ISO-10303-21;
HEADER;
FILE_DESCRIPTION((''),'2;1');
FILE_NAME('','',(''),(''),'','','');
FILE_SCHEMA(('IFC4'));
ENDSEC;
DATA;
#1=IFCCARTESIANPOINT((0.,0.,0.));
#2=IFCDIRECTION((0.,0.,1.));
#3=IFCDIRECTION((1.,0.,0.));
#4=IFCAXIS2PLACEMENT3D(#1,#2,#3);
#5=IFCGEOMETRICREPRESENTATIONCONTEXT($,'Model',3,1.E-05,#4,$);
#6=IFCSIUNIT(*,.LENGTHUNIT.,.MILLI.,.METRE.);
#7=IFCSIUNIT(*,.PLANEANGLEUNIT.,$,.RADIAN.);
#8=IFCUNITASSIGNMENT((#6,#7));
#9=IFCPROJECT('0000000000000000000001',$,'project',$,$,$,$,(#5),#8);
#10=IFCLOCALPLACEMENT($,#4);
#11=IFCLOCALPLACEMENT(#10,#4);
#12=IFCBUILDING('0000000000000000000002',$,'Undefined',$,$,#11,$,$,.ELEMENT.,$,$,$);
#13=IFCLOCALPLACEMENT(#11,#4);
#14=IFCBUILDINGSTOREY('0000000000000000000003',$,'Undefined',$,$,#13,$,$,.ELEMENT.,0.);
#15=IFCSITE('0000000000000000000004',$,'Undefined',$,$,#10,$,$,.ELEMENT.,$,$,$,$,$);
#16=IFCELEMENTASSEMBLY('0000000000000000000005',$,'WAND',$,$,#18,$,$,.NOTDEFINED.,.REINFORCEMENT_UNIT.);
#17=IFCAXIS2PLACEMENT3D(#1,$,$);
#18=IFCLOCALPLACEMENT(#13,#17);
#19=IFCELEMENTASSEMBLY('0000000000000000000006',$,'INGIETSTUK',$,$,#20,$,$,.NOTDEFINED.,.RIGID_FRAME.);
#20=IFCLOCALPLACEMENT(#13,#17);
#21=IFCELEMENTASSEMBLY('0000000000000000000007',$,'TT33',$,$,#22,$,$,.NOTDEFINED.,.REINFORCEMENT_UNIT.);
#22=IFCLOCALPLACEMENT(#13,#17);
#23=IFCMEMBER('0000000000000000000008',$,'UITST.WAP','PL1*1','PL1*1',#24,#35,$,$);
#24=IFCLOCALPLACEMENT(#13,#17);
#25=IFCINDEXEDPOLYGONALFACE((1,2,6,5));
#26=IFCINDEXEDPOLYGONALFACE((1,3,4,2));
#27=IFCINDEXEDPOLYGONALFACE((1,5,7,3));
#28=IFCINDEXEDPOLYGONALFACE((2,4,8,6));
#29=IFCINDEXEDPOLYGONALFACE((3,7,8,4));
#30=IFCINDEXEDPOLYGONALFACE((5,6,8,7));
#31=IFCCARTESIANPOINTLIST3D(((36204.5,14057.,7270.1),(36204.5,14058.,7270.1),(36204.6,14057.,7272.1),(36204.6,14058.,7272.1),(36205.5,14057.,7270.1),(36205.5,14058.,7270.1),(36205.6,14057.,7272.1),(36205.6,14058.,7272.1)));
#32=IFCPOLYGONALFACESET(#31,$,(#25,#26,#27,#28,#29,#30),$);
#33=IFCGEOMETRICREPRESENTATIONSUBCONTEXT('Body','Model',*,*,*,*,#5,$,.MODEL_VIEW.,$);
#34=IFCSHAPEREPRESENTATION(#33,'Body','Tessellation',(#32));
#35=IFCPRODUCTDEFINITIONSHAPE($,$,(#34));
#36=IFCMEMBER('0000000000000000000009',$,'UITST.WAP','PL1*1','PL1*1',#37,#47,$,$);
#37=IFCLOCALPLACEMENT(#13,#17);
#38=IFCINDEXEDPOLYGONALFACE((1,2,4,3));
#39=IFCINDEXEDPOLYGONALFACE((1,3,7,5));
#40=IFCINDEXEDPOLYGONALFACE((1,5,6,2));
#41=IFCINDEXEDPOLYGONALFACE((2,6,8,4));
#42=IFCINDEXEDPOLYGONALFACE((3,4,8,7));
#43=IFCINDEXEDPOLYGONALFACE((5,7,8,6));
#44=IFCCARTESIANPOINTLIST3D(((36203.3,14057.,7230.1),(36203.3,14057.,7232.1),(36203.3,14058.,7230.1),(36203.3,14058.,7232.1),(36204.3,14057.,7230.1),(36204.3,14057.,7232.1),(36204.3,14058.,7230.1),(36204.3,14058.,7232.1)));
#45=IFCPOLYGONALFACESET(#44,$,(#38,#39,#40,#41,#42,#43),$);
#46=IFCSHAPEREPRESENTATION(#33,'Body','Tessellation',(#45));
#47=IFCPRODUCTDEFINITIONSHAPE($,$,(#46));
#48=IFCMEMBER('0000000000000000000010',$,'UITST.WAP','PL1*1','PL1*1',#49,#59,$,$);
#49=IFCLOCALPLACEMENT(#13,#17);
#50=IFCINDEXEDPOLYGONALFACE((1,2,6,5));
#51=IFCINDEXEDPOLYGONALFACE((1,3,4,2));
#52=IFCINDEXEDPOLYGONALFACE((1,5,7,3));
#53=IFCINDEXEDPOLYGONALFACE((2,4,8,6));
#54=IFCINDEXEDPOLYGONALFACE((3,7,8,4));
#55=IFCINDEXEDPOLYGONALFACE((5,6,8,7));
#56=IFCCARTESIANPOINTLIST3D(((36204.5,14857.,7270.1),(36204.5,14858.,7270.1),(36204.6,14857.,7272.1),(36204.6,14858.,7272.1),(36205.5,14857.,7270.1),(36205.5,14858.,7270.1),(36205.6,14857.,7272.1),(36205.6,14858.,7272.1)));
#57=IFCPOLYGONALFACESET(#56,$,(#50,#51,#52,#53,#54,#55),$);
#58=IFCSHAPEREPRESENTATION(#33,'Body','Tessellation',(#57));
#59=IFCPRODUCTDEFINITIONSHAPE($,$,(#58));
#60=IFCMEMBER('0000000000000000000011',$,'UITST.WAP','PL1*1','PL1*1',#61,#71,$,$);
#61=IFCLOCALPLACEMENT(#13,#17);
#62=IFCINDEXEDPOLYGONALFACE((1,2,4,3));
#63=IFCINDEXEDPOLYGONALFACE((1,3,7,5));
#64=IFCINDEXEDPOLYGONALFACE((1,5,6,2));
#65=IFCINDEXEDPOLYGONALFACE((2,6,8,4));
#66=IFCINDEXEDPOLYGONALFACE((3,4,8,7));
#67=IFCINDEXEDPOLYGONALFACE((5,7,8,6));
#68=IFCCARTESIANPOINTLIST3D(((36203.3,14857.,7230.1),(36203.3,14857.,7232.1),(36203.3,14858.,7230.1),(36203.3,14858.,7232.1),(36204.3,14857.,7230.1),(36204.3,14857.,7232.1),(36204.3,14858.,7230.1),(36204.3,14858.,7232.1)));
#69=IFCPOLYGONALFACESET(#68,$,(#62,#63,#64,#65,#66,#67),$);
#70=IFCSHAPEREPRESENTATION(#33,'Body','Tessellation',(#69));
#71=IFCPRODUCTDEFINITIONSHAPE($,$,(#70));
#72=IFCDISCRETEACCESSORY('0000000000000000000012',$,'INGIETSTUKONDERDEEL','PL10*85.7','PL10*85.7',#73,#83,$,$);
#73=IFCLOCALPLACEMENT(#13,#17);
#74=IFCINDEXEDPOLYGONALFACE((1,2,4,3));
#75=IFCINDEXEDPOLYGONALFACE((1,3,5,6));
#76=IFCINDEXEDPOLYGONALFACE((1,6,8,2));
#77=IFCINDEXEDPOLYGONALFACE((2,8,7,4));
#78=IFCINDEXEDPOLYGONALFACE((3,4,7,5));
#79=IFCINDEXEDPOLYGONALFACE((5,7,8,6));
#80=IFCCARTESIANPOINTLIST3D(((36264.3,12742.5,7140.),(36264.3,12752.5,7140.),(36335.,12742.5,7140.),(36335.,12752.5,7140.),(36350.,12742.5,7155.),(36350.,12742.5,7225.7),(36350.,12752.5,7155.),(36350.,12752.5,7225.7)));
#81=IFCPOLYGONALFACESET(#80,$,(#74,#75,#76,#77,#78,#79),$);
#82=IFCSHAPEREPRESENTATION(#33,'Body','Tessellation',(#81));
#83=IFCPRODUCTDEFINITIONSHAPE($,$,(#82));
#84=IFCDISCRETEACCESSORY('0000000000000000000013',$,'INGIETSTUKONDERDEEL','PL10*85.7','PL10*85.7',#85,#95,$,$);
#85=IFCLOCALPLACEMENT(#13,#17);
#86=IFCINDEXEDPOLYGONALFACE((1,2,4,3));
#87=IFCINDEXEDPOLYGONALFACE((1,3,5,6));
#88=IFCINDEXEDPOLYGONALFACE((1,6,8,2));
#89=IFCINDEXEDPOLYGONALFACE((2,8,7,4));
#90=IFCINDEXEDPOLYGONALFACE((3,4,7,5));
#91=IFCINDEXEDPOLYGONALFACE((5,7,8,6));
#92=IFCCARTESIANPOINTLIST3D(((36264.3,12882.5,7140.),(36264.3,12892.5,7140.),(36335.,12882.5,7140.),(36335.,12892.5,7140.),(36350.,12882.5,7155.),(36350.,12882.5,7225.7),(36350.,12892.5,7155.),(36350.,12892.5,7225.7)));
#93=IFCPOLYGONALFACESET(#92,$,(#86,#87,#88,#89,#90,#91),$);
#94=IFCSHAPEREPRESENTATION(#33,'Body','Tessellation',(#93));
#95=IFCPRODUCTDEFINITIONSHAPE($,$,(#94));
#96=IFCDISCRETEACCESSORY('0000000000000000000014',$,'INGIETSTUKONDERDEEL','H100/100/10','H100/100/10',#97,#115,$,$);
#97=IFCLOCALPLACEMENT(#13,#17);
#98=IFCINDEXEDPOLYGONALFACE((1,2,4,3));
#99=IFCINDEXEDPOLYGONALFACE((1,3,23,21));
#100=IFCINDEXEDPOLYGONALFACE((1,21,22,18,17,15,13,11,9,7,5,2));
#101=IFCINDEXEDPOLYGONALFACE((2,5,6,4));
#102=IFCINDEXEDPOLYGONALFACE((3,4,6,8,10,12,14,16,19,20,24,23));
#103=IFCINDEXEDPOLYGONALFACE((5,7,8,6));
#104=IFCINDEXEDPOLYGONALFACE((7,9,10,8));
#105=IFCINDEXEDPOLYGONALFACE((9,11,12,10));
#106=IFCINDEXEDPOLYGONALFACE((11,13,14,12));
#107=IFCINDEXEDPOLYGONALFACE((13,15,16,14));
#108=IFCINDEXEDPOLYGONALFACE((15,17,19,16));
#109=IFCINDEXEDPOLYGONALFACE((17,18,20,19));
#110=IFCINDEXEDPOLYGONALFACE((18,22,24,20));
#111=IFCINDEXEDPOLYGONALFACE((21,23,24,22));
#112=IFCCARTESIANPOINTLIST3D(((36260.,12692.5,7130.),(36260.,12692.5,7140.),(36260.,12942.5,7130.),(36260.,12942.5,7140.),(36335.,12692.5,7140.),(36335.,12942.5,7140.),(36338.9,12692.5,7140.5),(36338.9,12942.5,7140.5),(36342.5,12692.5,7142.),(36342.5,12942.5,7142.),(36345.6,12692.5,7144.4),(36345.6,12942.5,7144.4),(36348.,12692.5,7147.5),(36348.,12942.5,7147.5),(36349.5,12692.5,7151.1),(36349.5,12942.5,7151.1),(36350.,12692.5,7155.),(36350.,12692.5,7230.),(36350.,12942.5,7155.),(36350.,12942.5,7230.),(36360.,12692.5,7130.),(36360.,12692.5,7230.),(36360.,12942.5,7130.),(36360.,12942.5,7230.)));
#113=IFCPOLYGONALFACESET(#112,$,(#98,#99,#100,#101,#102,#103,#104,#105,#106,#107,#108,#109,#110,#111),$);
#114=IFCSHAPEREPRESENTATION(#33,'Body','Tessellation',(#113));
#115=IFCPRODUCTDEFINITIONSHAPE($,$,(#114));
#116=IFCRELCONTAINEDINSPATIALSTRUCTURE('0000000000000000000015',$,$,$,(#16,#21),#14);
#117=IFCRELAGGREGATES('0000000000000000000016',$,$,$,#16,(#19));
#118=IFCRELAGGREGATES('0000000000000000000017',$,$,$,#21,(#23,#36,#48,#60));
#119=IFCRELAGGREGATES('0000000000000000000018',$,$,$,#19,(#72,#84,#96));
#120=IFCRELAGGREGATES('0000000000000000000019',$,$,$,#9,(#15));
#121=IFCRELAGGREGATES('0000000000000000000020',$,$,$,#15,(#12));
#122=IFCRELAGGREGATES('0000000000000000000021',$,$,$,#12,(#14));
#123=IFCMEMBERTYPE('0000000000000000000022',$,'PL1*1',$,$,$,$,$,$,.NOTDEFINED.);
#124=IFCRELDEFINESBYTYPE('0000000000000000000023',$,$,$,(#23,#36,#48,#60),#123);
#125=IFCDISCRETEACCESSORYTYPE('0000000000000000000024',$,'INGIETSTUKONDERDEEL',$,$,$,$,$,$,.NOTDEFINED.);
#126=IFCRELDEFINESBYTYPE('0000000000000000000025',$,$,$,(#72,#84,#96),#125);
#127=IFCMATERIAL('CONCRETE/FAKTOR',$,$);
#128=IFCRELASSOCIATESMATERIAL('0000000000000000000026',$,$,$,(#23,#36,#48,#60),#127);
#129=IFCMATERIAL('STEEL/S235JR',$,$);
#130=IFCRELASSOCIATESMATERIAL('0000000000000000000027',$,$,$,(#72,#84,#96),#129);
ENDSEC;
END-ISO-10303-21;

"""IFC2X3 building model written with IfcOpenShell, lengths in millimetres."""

from ifc_helpers import new_model, si_unit, frame, frame_2d, origin_with_axes, place, context, subcontext, project, spatial, polyline, rectangle, l_section, outline, extrude, material, type_object, element, aggregate, save


model = new_model("IFC2X3")

# Units and contexts
model_context = context("Model", 3, precision=1e-05, world=origin_with_axes())
body_context = subcontext(model_context, "Body", "Model", "MODEL_VIEW")
ifc_project = project(units=[si_unit("LENGTHUNIT", "METRE", prefix="MILLI"), si_unit("PLANEANGLEUNIT", "RADIAN")], contexts=[model_context])

# Site, building, storey
site_placement = place(None, origin_with_axes())
site = spatial("IfcSite", under=ifc_project, at=site_placement, Name="Undefined", CompositionType="ELEMENT")
building_placement = place(site_placement, origin_with_axes())
building = spatial("IfcBuilding", under=site, at=building_placement, Name="Undefined", CompositionType="ELEMENT")
storey_placement = place(building_placement, origin_with_axes())
storey = spatial("IfcBuildingStorey", under=building, at=storey_placement, Name="Undefined", CompositionType="ELEMENT", Elevation=0.0)

# Shared definitions
ifc_material_1 = material(Name="CONCRETE/FAKTOR")

# Element assemblies
assembly_1_placement = place(storey_placement, origin_with_axes())
assembly_1 = element("IfcElementAssembly", 1, at=assembly_1_placement, inside=storey, Name="WAND", AssemblyPlace="NOTDEFINED", PredefinedType="REINFORCEMENT_UNIT")
assembly_2_placement = place(assembly_1_placement, origin_with_axes())
assembly_2 = element("IfcElementAssembly", 2, at=assembly_2_placement, Name="INGIETSTUK", AssemblyPlace="NOTDEFINED", PredefinedType="RIGID_FRAME")
ifc_material_2 = material(Name="STEEL/S235JR")

aggregate(assembly_1, [assembly_2])

# Element assembly, members
member_type = type_object("IfcMemberType", Name="PL1*1", PredefinedType="NOTDEFINED")
assembly_3_placement = place(storey_placement, origin_with_axes())
assembly_3 = element("IfcElementAssembly", 3, at=assembly_3_placement, inside=storey, Name="TT33", AssemblyPlace="NOTDEFINED", PredefinedType="REINFORCEMENT_UNIT")
member_1_placement = place(assembly_3_placement, frame((36205.0, 14057.5, 7270.1), z_axis=(0.0, -1.0, 0.0), x_axis=(0.031107, 0.0, 0.999516)))
member_1 = element("IfcMember", 4, at=member_1_placement, type_object=member_type, material=ifc_material_1, Name="UITST.WAP", Description="PL1*1", ObjectType="PL1*1", context=body_context, shape_type="SweptSolid", body=[
    extrude(rectangle(XDim=1.0, YDim=1.0, at=frame_2d((0.0, 0.0), x_axis=(1.0, 0.0))), frame((2.0, 0.0, 0.0), z_axis=(-1.0, 0.0, 0.0), x_axis=(0.0, -1.0, 0.0)), (0.0, 0.0, 1.0), 2.0),
])
member_2_placement = place(assembly_3_placement, frame((36203.8, 14057.5, 7230.1), z_axis=(0.0, -1.0, 0.0), x_axis=(0.031107, 0.0, 0.999516)))
member_2 = element("IfcMember", 5, at=member_2_placement, type_object=member_type, material=ifc_material_1, Name="UITST.WAP", Description="PL1*1", ObjectType="PL1*1", context=body_context, shape_type="SweptSolid", body=[
    extrude(rectangle(XDim=1.0, YDim=1.0, at=frame_2d((0.0, 0.0), x_axis=(1.0, 0.0))), frame((2.0, 0.0, 0.0), z_axis=(-1.0, 0.0, 0.0), x_axis=(0.0, -1.0, 0.0)), (0.0, 0.0, 1.0), 2.0),
])
member_3_placement = place(assembly_3_placement, frame((36205.0, 14857.5, 7270.1), z_axis=(0.0, -1.0, 0.0), x_axis=(0.031107, 0.0, 0.999516)))
member_3 = element("IfcMember", 6, at=member_3_placement, type_object=member_type, material=ifc_material_1, Name="UITST.WAP", Description="PL1*1", ObjectType="PL1*1", context=body_context, shape_type="SweptSolid", body=[
    extrude(rectangle(XDim=1.0, YDim=1.0, at=frame_2d((0.0, 0.0), x_axis=(1.0, 0.0))), frame((2.0, 0.0, 0.0), z_axis=(-1.0, 0.0, 0.0), x_axis=(0.0, -1.0, 0.0)), (0.0, 0.0, 1.0), 2.0),
])
member_4_placement = place(assembly_3_placement, frame((36203.8, 14857.5, 7230.1), z_axis=(0.0, -1.0, 0.0), x_axis=(0.031107, 0.0, 0.999516)))
member_4 = element("IfcMember", 7, at=member_4_placement, type_object=member_type, material=ifc_material_1, Name="UITST.WAP", Description="PL1*1", ObjectType="PL1*1", context=body_context, shape_type="SweptSolid", body=[
    extrude(rectangle(XDim=1.0, YDim=1.0, at=frame_2d((0.0, 0.0), x_axis=(1.0, 0.0))), frame((2.0, 0.0, 0.0), z_axis=(-1.0, 0.0, 0.0), x_axis=(0.0, -1.0, 0.0)), (0.0, 0.0, 1.0), 2.0),
])
aggregate(assembly_3, [member_1, member_2, member_3, member_4])

# Discrete accessories
discrete_accessory_type = type_object("IfcDiscreteAccessoryType", Name="INGIETSTUKONDERDEEL")
discrete_accessory_1_placement = place(assembly_2_placement, frame((36350.0, 12747.5, 7225.7), z_axis=(0.0, 1.0, 0.0), x_axis=(0.0, 0.0, -1.0)))
discrete_accessory_1 = element("IfcDiscreteAccessory", 8, at=discrete_accessory_1_placement, type_object=discrete_accessory_type, material=ifc_material_2, Name="INGIETSTUKONDERDEEL", Description="PL10*85.7", ObjectType="PL10*85.7", context=body_context, shape_type="SweptSolid", body=[
    extrude(outline(polyline([(0.0, 0.0), (70.7, 0.0), (85.7, 15.0), (85.7, 85.7), (0.0, 0.0)])), frame((0.0, 0.0, -5.0), z_axis=(0.0, 0.0, 1.0), x_axis=(1.0, 0.0, 0.0)), (0.0, 0.0, 1.0), 10.0),
])
discrete_accessory_2_placement = place(assembly_2_placement, frame((36350.0, 12887.5, 7225.7), z_axis=(0.0, 1.0, 0.0), x_axis=(0.0, 0.0, -1.0)))
discrete_accessory_2 = element("IfcDiscreteAccessory", 9, at=discrete_accessory_2_placement, type_object=discrete_accessory_type, material=ifc_material_2, Name="INGIETSTUKONDERDEEL", Description="PL10*85.7", ObjectType="PL10*85.7", context=body_context, shape_type="SweptSolid", body=[
    extrude(outline(polyline([(0.0, 0.0), (70.7, 0.0), (85.7, 15.0), (85.7, 85.7), (0.0, 0.0)])), frame((0.0, 0.0, -5.0), z_axis=(0.0, 0.0, 1.0), x_axis=(1.0, 0.0, 0.0)), (0.0, 0.0, 1.0), 10.0),
])
discrete_accessory_3_placement = place(assembly_2_placement, frame((36310.0, 12942.5, 7180.0), z_axis=(0.0, 0.0, 1.0), x_axis=(0.0, -1.0, 0.0)))
discrete_accessory_3 = element("IfcDiscreteAccessory", 10, at=discrete_accessory_3_placement, type_object=discrete_accessory_type, material=ifc_material_2, Name="INGIETSTUKONDERDEEL", Description="H100/100/10", ObjectType="H100/100/10", context=body_context, shape_type="SweptSolid", body=[
    extrude(l_section(Depth=100.0, Width=100.0, Thickness=10.0, FilletRadius=15.0, at=frame_2d((0.0, 0.0), x_axis=(1.0, 0.0))), frame((250.0, 0.0, 0.0), z_axis=(-1.0, 0.0, 0.0), x_axis=(0.0, -1.0, 0.0)), (0.0, 0.0, 1.0), 250.0),
])
aggregate(assembly_2, [discrete_accessory_1, discrete_accessory_2, discrete_accessory_3])

save(model, "model.ifc")
